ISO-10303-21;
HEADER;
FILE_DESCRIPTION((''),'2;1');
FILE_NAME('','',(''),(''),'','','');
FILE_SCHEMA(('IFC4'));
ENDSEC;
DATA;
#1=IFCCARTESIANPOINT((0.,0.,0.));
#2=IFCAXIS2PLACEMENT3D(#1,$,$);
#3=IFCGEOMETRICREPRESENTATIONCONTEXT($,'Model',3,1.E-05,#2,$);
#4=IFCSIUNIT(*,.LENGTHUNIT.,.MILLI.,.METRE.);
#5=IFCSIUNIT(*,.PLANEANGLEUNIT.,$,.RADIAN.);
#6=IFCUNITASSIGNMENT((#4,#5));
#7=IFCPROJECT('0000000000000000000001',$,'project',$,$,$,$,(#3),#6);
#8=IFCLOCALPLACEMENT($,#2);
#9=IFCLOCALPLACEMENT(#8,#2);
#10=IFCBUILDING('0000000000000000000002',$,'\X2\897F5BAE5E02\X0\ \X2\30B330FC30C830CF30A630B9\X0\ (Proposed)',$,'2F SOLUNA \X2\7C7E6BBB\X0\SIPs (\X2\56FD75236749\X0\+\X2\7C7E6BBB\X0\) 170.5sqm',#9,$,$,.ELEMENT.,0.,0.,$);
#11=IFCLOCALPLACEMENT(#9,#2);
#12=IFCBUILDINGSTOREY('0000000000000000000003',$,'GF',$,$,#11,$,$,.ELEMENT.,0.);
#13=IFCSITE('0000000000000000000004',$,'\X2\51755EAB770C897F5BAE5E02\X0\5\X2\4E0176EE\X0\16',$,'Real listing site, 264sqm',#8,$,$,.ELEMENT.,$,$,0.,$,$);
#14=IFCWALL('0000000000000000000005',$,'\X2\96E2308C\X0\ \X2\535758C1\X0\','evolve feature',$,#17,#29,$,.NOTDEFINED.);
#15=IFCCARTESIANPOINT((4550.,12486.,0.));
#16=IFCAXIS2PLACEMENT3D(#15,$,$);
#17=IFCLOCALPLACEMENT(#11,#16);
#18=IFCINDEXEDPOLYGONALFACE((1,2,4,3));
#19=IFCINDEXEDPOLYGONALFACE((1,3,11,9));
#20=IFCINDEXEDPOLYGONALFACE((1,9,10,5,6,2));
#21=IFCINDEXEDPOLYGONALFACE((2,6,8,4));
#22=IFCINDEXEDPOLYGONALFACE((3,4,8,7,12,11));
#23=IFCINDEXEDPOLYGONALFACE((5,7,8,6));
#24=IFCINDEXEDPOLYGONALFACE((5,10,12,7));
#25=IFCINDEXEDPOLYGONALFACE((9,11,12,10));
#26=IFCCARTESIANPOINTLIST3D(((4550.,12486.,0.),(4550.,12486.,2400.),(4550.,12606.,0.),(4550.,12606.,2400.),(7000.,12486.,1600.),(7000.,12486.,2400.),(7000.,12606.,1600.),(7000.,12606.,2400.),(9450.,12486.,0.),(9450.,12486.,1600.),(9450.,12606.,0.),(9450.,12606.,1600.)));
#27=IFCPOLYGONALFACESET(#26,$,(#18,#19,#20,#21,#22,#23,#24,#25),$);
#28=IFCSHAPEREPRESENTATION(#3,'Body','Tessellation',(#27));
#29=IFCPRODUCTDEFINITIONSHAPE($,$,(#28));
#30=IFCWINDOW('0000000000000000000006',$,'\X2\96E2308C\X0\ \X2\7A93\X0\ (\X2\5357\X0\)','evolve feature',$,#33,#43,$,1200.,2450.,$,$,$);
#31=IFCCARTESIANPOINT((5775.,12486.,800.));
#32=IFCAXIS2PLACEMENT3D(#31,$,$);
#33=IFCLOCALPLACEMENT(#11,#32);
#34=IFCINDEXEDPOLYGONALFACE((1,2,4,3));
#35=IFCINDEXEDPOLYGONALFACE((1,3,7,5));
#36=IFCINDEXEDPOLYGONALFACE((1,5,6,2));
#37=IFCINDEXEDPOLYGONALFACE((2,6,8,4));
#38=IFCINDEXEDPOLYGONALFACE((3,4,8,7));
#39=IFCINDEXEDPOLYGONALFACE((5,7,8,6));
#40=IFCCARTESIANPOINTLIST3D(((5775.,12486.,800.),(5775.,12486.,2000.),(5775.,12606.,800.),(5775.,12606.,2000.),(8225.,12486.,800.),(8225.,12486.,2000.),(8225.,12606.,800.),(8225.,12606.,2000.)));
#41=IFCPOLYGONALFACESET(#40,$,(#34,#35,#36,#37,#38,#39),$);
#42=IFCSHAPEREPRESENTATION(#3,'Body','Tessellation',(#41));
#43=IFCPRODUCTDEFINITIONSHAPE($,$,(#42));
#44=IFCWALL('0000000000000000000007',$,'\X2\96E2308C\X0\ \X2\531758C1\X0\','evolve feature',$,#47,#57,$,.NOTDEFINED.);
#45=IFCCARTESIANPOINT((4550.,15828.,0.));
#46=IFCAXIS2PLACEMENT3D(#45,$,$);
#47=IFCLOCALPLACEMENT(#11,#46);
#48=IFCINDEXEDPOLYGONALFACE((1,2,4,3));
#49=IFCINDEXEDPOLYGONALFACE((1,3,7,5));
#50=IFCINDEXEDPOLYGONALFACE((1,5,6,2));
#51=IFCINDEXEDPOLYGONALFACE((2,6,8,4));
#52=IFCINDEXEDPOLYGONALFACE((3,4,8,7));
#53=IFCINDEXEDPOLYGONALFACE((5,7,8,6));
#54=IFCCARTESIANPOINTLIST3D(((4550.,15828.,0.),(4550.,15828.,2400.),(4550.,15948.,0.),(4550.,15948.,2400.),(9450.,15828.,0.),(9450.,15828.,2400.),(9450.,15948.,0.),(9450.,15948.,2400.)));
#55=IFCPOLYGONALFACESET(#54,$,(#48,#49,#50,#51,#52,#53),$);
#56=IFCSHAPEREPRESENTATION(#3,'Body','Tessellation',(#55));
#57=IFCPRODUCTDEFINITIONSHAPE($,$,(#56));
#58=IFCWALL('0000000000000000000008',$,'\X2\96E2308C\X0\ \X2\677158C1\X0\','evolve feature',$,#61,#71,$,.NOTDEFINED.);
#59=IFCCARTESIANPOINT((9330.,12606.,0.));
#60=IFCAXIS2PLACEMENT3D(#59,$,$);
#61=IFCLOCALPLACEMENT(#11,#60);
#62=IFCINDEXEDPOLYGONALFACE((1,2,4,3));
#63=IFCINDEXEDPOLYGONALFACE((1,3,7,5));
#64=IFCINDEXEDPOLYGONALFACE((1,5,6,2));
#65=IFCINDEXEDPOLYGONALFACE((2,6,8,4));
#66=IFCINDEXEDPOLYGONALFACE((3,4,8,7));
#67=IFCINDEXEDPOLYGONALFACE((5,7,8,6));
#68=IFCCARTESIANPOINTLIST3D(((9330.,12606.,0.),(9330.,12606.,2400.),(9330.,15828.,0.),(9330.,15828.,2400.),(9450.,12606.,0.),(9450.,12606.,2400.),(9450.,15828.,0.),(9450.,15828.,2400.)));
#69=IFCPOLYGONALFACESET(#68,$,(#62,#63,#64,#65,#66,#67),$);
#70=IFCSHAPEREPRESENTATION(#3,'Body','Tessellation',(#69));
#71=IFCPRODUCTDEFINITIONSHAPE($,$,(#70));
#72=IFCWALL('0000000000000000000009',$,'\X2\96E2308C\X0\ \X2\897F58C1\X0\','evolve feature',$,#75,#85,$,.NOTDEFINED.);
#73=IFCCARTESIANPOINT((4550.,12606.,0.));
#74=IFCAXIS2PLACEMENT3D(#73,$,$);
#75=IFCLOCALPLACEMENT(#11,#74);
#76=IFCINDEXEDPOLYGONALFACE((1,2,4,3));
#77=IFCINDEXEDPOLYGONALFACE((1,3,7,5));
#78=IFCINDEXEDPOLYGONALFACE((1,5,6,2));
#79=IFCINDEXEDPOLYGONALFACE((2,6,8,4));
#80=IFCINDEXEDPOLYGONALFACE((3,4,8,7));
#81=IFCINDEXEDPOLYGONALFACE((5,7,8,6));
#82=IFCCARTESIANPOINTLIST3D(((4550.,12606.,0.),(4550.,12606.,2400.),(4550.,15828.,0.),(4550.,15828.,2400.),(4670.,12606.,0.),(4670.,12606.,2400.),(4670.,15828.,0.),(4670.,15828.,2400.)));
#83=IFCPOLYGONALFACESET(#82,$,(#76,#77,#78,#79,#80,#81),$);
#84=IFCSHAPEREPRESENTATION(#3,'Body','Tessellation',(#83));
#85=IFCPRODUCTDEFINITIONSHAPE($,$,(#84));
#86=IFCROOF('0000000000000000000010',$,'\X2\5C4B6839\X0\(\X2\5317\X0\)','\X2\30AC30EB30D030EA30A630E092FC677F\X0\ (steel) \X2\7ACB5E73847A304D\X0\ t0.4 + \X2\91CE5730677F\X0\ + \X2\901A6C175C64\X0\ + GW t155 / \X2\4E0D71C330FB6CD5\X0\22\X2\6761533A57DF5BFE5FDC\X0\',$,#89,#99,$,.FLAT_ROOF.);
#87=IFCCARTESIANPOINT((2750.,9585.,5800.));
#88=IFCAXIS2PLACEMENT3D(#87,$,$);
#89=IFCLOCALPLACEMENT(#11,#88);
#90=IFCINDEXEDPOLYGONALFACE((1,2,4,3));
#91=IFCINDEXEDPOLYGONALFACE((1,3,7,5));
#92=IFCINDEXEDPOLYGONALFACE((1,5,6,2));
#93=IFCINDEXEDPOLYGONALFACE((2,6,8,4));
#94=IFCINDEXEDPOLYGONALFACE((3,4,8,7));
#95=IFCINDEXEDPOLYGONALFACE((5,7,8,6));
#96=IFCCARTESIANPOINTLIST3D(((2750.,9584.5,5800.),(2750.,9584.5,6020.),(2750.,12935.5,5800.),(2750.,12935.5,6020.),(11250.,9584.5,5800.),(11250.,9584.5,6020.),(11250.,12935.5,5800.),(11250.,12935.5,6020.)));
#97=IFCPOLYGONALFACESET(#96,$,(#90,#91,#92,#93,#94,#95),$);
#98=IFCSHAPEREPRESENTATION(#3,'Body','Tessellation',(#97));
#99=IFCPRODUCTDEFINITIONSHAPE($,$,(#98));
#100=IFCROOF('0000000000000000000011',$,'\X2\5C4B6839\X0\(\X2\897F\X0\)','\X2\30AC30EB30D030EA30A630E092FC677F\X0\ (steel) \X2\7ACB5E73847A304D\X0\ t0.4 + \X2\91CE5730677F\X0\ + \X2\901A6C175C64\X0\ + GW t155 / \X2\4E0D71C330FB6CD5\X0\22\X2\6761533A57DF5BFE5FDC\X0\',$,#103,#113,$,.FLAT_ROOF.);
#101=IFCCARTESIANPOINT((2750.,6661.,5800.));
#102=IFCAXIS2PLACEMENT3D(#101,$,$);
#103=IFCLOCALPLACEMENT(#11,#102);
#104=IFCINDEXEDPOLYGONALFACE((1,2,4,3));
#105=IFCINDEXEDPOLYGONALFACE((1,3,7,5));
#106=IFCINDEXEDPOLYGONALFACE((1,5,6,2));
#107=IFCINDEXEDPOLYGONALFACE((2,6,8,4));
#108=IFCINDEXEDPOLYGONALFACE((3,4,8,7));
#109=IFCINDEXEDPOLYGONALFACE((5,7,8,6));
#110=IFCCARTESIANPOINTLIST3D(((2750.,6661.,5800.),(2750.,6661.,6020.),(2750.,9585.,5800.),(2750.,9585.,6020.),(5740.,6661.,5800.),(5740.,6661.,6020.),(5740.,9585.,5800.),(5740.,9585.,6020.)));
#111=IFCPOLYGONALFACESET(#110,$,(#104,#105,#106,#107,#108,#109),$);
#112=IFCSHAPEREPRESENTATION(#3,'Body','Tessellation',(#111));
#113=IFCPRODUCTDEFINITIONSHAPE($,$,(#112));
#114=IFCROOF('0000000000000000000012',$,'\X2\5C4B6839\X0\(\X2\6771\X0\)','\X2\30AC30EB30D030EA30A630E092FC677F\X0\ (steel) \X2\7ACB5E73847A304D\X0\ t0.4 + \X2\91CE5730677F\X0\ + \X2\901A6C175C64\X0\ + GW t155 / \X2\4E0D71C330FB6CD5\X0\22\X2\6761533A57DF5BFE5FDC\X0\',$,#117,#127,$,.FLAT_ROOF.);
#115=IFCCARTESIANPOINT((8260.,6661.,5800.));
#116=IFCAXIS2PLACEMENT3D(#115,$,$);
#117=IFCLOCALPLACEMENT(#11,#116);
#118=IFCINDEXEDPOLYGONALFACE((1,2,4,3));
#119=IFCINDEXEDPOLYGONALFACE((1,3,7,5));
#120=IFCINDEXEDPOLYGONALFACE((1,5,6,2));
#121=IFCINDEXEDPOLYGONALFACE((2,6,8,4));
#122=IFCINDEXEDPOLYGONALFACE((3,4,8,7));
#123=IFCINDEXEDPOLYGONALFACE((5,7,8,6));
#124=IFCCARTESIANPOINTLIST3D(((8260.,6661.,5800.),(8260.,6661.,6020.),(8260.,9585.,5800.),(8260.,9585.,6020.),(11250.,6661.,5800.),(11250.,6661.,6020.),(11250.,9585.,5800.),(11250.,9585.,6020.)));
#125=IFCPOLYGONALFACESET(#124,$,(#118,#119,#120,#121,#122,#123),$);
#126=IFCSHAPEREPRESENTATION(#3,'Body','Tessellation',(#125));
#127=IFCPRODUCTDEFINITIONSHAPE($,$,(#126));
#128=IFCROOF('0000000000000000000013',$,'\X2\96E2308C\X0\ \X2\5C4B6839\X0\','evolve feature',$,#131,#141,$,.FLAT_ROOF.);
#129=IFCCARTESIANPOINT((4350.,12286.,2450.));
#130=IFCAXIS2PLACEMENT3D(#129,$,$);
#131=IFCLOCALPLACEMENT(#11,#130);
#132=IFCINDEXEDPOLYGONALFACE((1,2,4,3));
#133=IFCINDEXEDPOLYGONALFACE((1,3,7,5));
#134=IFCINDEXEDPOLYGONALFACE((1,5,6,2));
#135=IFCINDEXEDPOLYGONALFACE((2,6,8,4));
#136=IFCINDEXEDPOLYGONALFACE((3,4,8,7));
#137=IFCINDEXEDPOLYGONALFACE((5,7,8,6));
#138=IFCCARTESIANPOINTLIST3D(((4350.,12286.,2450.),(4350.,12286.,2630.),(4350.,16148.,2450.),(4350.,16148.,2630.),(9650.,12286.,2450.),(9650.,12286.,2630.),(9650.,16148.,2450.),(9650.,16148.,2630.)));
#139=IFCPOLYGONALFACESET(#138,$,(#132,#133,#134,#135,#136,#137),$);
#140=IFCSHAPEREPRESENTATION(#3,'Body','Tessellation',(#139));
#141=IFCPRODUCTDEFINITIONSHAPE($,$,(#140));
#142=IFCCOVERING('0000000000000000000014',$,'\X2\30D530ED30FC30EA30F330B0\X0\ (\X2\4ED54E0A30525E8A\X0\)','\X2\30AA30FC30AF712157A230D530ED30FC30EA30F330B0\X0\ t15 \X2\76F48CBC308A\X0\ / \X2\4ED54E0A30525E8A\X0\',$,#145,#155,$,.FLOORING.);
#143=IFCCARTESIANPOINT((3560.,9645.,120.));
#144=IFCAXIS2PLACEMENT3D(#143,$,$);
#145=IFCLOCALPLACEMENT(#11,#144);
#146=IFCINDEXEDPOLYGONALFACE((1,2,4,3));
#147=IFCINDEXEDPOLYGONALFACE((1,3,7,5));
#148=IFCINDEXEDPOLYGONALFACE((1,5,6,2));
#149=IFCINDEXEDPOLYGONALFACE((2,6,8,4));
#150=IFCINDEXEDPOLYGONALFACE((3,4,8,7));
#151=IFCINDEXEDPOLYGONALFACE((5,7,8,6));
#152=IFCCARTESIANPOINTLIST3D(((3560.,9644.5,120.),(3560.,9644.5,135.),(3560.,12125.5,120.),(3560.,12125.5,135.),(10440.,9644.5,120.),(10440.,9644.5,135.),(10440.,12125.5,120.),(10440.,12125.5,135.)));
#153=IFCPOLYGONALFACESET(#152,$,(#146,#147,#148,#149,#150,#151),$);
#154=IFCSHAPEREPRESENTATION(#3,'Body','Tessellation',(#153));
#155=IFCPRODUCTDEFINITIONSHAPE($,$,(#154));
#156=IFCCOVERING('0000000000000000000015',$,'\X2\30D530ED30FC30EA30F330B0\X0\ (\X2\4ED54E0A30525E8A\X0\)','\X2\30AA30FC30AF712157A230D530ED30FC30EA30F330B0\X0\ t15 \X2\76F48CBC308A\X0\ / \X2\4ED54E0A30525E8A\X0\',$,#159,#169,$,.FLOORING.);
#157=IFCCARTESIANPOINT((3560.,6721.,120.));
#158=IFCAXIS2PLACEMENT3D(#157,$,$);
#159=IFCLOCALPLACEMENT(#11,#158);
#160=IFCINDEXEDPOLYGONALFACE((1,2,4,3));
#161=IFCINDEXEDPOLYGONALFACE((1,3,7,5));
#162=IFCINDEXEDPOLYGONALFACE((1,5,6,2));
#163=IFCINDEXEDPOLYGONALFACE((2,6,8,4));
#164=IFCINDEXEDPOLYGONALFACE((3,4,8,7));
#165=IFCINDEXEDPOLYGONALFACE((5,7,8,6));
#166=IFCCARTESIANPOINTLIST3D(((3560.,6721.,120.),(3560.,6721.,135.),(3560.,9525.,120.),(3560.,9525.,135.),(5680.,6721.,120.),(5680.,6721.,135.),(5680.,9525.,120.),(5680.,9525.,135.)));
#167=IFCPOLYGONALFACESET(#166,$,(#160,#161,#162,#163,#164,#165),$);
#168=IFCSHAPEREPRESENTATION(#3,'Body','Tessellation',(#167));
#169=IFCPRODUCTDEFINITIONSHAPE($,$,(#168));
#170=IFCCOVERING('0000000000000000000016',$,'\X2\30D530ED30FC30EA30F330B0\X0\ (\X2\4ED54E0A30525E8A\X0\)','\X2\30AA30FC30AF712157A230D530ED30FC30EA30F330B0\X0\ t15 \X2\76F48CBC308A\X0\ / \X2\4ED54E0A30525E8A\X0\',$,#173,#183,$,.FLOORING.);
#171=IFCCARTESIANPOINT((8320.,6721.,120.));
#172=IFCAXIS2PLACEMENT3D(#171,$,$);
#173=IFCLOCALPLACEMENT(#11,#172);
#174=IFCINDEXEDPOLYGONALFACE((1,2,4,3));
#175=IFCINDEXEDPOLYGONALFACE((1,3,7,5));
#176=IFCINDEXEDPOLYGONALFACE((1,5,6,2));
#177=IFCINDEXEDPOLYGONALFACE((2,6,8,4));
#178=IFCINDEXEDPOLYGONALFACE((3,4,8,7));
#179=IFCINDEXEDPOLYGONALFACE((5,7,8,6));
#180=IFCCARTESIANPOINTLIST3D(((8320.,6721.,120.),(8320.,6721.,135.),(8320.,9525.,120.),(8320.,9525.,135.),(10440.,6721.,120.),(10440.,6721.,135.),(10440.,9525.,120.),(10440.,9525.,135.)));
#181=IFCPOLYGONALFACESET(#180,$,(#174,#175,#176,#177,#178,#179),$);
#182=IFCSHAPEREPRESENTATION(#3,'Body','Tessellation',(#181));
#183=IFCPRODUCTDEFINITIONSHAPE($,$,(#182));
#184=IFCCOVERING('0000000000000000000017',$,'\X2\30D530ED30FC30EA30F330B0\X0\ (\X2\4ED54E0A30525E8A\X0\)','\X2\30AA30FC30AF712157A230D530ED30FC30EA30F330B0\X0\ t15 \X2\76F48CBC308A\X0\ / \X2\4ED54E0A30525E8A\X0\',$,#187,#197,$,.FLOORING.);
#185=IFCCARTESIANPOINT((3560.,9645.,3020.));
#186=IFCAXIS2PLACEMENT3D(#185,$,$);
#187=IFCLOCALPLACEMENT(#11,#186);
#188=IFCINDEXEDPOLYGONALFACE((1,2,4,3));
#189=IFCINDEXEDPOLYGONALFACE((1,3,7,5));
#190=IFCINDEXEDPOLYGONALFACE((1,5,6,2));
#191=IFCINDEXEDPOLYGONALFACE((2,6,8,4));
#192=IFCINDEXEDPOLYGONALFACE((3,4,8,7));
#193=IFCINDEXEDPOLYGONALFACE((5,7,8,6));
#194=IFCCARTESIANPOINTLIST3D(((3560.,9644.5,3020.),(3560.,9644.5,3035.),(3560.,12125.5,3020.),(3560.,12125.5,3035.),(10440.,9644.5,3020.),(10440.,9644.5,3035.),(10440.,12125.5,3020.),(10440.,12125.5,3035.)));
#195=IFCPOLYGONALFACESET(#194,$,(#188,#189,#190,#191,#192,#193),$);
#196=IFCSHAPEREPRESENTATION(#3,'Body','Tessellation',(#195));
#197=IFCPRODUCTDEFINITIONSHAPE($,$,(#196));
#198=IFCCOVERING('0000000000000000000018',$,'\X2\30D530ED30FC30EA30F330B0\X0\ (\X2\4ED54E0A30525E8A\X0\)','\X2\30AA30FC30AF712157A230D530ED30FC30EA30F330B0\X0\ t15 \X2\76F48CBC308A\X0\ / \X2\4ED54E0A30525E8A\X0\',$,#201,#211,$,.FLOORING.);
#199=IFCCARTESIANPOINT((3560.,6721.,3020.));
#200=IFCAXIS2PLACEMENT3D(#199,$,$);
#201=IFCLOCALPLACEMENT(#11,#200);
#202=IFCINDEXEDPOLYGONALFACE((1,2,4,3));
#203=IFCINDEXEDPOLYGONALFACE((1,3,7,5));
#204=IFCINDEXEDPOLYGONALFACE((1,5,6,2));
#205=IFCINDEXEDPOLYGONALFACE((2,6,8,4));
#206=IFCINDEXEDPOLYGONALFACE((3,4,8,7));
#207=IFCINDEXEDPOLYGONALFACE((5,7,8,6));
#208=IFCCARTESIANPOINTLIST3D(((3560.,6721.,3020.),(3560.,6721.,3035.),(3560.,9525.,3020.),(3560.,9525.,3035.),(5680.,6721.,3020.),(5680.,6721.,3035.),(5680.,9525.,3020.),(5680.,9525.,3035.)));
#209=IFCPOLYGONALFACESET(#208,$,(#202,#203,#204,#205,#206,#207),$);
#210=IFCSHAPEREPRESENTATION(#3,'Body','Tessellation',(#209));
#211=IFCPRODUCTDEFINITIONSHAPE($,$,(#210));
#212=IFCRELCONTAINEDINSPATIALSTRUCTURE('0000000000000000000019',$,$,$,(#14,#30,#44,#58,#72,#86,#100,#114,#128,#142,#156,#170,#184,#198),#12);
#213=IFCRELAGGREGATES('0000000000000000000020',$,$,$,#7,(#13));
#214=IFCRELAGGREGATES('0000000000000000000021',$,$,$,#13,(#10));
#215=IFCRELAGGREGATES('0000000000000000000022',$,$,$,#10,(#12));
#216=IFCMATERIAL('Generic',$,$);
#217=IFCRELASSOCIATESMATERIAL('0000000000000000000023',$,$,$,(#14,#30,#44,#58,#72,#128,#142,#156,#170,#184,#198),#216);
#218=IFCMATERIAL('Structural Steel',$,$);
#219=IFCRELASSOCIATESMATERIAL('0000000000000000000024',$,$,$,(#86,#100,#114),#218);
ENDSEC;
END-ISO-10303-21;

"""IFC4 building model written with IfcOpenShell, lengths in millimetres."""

from ifc_helpers import new_model, si_unit, frame, frame_2d, origin, place, context, project, spatial, rectangle, extrude, material, element, fill, save


model = new_model("IFC4")

# Units and contexts
model_context = context("Model", 3, precision=1e-05, world=origin())
ifc_project = project(units=[si_unit("LENGTHUNIT", "METRE", prefix="MILLI"), si_unit("PLANEANGLEUNIT", "RADIAN")], contexts=[model_context])

# Site, building, storey
site_placement = place(None, origin())
site = spatial("IfcSite", under=ifc_project, at=site_placement, Name="兵庫県西宮市5丁目16", ObjectType="Real listing site, 264sqm", CompositionType="ELEMENT", RefElevation=0.0)
building_placement = place(site_placement, origin())
building = spatial("IfcBuilding", under=site, at=building_placement, Name="西宮市 コートハウス (Proposed)", ObjectType="2F SOLUNA 籾殻SIPs (国産杉+籾殻) 170.5sqm", CompositionType="ELEMENT", ElevationOfRefHeight=0.0, ElevationOfTerrain=0.0)
storey_placement = place(building_placement, origin())
storey = spatial("IfcBuildingStorey", under=building, at=storey_placement, Name="GF", CompositionType="ELEMENT", Elevation=0.0)

# Shared definitions
ifc_material_1 = material(Name="Generic")

# Wall, opening, window
wall_1_placement = place(storey_placement, frame((4550.0, 12486.0, 0.0)))
wall_1 = element("IfcWall", 1, at=wall_1_placement, inside=storey, material=ifc_material_1, Name="離れ 南壁", Description="evolve feature", PredefinedType="NOTDEFINED", context=model_context, shape_type="SweptSolid", body=[
    extrude(rectangle(XDim=4900.0, YDim=120.0, at=frame_2d((2450.0, 60.0))), frame((4550.0, 12486.0, 0.0)), (0.0, 0.0, 1.0), 2400.0),
])
opening_1_placement = place(storey_placement, frame((5775.0, 12486.0, 800.0)))
opening_1 = element("IfcOpeningElement", 2, at=opening_1_placement, cuts=wall_1, PredefinedType="NOTDEFINED", context=model_context, shape_type="SweptSolid", body=[
    extrude(rectangle(XDim=2450.0, YDim=120.0, at=frame_2d((1225.0, 60.0))), frame((5775.0, 12486.0, 800.0)), (0.0, 0.0, 1.0), 1200.0),
])
window_1_placement = place(storey_placement, frame((5775.0, 12486.0, 800.0)))
window_1 = element("IfcWindow", 3, at=window_1_placement, inside=storey, material=ifc_material_1, Name="離れ 窓 (南)", Description="evolve feature", OverallHeight=1200.0, OverallWidth=2450.0, context=model_context, shape_type="SweptSolid", body=[
    extrude(rectangle(XDim=2450.0, YDim=120.0, at=frame_2d((1225.0, 60.0))), frame((5775.0, 12486.0, 800.0)), (0.0, 0.0, 1.0), 1200.0),
])
fill(opening_1, window_1)

# Walls
wall_2_placement = place(storey_placement, frame((4550.0, 15828.0, 0.0)))
element("IfcWall", 4, at=wall_2_placement, inside=storey, material=ifc_material_1, Name="離れ 北壁", Description="evolve feature", PredefinedType="NOTDEFINED", context=model_context, shape_type="SweptSolid", body=[
    extrude(rectangle(XDim=4900.0, YDim=120.0, at=frame_2d((2450.0, 60.0))), frame((4550.0, 15828.0, 0.0)), (0.0, 0.0, 1.0), 2400.0),
])
wall_3_placement = place(storey_placement, frame((9330.0, 12606.0, 0.0)))
element("IfcWall", 5, at=wall_3_placement, inside=storey, material=ifc_material_1, Name="離れ 東壁", Description="evolve feature", PredefinedType="NOTDEFINED", context=model_context, shape_type="SweptSolid", body=[
    extrude(rectangle(XDim=120.0, YDim=3222.0, at=frame_2d((60.0, 1611.0))), frame((9330.0, 12606.0, 0.0)), (0.0, 0.0, 1.0), 2400.0),
])
wall_4_placement = place(storey_placement, frame((4550.0, 12606.0, 0.0)))
element("IfcWall", 6, at=wall_4_placement, inside=storey, material=ifc_material_1, Name="離れ 西壁", Description="evolve feature", PredefinedType="NOTDEFINED", context=model_context, shape_type="SweptSolid", body=[
    extrude(rectangle(XDim=120.0, YDim=3222.0, at=frame_2d((60.0, 1611.0))), frame((4550.0, 12606.0, 0.0)), (0.0, 0.0, 1.0), 2400.0),
])

# Roofs
ifc_material_2 = material(Name="Structural Steel")
for number, where, name in (
    (7, (2750.0, 9585.0, 5800.0), "屋根(北)"),
):
    element("IfcRoof", number, at=place(storey_placement, frame(where)), inside=storey, material=ifc_material_2, Name=name, Description="ガルバリウム鋼板 (steel) 立平葺き t0.4 + 野地板 + 通気層 + GW t155 / 不燃・法22条区域対応", PredefinedType="FLAT_ROOF", context=model_context, shape_type="SweptSolid", body=[
        extrude(rectangle(XDim=8500.0, YDim=3351.0, at=frame_2d((4250.0, 1675.0))), frame((2750.0, 9585.0, 5800.0)), (0.0, 0.0, 1.0), 220.0),
    ])
roof_1_placement = place(storey_placement, frame((2750.0, 6661.0, 5800.0)))
element("IfcRoof", 8, at=roof_1_placement, inside=storey, material=ifc_material_2, Name="屋根(西)", Description="ガルバリウム鋼板 (steel) 立平葺き t0.4 + 野地板 + 通気層 + GW t155 / 不燃・法22条区域対応", PredefinedType="FLAT_ROOF", context=model_context, shape_type="SweptSolid", body=[
    extrude(rectangle(XDim=2990.0, YDim=2924.0, at=frame_2d((1495.0, 1462.0))), frame((2750.0, 6661.0, 5800.0)), (0.0, 0.0, 1.0), 220.0),
])
roof_2_placement = place(storey_placement, frame((8260.0, 6661.0, 5800.0)))
element("IfcRoof", 9, at=roof_2_placement, inside=storey, material=ifc_material_2, Name="屋根(東)", Description="ガルバリウム鋼板 (steel) 立平葺き t0.4 + 野地板 + 通気層 + GW t155 / 不燃・法22条区域対応", PredefinedType="FLAT_ROOF", context=model_context, shape_type="SweptSolid", body=[
    extrude(rectangle(XDim=2990.0, YDim=2924.0, at=frame_2d((1495.0, 1462.0))), frame((8260.0, 6661.0, 5800.0)), (0.0, 0.0, 1.0), 220.0),
])
roof_3_placement = place(storey_placement, frame((4350.0, 12286.0, 2450.0)))
element("IfcRoof", 10, at=roof_3_placement, inside=storey, material=ifc_material_1, Name="離れ 屋根", Description="evolve feature", PredefinedType="FLAT_ROOF", context=model_context, shape_type="SweptSolid", body=[
    extrude(rectangle(XDim=5300.0, YDim=3862.0, at=frame_2d((2650.0, 1931.0))), frame((4350.0, 12286.0, 2450.0)), (0.0, 0.0, 1.0), 180.0),
])

# Coverings
covering_1_placement = place(storey_placement, frame((3560.0, 9645.0, 120.0)))
element("IfcCovering", 11, at=covering_1_placement, inside=storey, material=ifc_material_1, Name="フローリング (仕上げ床)", Description="オーク無垢フローリング t15 直貼り / 仕上げ床", PredefinedType="FLOORING", context=model_context, shape_type="SweptSolid", body=[
    extrude(rectangle(XDim=6880.0, YDim=2481.0, at=frame_2d((3440.0, 1240.0))), frame((3560.0, 9645.0, 120.0)), (0.0, 0.0, 1.0), 15.0),
])
covering_2_placement = place(storey_placement, frame((3560.0, 6721.0, 120.0)))
element("IfcCovering", 12, at=covering_2_placement, inside=storey, material=ifc_material_1, Name="フローリング (仕上げ床)", Description="オーク無垢フローリング t15 直貼り / 仕上げ床", PredefinedType="FLOORING", context=model_context, shape_type="SweptSolid", body=[
    extrude(rectangle(XDim=2120.0, YDim=2804.0, at=frame_2d((1060.0, 1402.0))), frame((3560.0, 6721.0, 120.0)), (0.0, 0.0, 1.0), 15.0),
])
covering_3_placement = place(storey_placement, frame((8320.0, 6721.0, 120.0)))
element("IfcCovering", 13, at=covering_3_placement, inside=storey, material=ifc_material_1, Name="フローリング (仕上げ床)", Description="オーク無垢フローリング t15 直貼り / 仕上げ床", PredefinedType="FLOORING", context=model_context, shape_type="SweptSolid", body=[
    extrude(rectangle(XDim=2120.0, YDim=2804.0, at=frame_2d((1060.0, 1402.0))), frame((8320.0, 6721.0, 120.0)), (0.0, 0.0, 1.0), 15.0),
])
covering_4_placement = place(storey_placement, frame((3560.0, 9645.0, 3020.0)))
element("IfcCovering", 14, at=covering_4_placement, inside=storey, material=ifc_material_1, Name="フローリング (仕上げ床)", Description="オーク無垢フローリング t15 直貼り / 仕上げ床", PredefinedType="FLOORING", context=model_context, shape_type="SweptSolid", body=[
    extrude(rectangle(XDim=6880.0, YDim=2481.0, at=frame_2d((3440.0, 1240.0))), frame((3560.0, 9645.0, 3020.0)), (0.0, 0.0, 1.0), 15.0),
])
covering_5_placement = place(storey_placement, frame((3560.0, 6721.0, 3020.0)))
element("IfcCovering", 15, at=covering_5_placement, inside=storey, material=ifc_material_1, Name="フローリング (仕上げ床)", Description="オーク無垢フローリング t15 直貼り / 仕上げ床", PredefinedType="FLOORING", context=model_context, shape_type="SweptSolid", body=[
    extrude(rectangle(XDim=2120.0, YDim=2804.0, at=frame_2d((1060.0, 1402.0))), frame((3560.0, 6721.0, 3020.0)), (0.0, 0.0, 1.0), 15.0),
])

save(model, "model.ifc")
